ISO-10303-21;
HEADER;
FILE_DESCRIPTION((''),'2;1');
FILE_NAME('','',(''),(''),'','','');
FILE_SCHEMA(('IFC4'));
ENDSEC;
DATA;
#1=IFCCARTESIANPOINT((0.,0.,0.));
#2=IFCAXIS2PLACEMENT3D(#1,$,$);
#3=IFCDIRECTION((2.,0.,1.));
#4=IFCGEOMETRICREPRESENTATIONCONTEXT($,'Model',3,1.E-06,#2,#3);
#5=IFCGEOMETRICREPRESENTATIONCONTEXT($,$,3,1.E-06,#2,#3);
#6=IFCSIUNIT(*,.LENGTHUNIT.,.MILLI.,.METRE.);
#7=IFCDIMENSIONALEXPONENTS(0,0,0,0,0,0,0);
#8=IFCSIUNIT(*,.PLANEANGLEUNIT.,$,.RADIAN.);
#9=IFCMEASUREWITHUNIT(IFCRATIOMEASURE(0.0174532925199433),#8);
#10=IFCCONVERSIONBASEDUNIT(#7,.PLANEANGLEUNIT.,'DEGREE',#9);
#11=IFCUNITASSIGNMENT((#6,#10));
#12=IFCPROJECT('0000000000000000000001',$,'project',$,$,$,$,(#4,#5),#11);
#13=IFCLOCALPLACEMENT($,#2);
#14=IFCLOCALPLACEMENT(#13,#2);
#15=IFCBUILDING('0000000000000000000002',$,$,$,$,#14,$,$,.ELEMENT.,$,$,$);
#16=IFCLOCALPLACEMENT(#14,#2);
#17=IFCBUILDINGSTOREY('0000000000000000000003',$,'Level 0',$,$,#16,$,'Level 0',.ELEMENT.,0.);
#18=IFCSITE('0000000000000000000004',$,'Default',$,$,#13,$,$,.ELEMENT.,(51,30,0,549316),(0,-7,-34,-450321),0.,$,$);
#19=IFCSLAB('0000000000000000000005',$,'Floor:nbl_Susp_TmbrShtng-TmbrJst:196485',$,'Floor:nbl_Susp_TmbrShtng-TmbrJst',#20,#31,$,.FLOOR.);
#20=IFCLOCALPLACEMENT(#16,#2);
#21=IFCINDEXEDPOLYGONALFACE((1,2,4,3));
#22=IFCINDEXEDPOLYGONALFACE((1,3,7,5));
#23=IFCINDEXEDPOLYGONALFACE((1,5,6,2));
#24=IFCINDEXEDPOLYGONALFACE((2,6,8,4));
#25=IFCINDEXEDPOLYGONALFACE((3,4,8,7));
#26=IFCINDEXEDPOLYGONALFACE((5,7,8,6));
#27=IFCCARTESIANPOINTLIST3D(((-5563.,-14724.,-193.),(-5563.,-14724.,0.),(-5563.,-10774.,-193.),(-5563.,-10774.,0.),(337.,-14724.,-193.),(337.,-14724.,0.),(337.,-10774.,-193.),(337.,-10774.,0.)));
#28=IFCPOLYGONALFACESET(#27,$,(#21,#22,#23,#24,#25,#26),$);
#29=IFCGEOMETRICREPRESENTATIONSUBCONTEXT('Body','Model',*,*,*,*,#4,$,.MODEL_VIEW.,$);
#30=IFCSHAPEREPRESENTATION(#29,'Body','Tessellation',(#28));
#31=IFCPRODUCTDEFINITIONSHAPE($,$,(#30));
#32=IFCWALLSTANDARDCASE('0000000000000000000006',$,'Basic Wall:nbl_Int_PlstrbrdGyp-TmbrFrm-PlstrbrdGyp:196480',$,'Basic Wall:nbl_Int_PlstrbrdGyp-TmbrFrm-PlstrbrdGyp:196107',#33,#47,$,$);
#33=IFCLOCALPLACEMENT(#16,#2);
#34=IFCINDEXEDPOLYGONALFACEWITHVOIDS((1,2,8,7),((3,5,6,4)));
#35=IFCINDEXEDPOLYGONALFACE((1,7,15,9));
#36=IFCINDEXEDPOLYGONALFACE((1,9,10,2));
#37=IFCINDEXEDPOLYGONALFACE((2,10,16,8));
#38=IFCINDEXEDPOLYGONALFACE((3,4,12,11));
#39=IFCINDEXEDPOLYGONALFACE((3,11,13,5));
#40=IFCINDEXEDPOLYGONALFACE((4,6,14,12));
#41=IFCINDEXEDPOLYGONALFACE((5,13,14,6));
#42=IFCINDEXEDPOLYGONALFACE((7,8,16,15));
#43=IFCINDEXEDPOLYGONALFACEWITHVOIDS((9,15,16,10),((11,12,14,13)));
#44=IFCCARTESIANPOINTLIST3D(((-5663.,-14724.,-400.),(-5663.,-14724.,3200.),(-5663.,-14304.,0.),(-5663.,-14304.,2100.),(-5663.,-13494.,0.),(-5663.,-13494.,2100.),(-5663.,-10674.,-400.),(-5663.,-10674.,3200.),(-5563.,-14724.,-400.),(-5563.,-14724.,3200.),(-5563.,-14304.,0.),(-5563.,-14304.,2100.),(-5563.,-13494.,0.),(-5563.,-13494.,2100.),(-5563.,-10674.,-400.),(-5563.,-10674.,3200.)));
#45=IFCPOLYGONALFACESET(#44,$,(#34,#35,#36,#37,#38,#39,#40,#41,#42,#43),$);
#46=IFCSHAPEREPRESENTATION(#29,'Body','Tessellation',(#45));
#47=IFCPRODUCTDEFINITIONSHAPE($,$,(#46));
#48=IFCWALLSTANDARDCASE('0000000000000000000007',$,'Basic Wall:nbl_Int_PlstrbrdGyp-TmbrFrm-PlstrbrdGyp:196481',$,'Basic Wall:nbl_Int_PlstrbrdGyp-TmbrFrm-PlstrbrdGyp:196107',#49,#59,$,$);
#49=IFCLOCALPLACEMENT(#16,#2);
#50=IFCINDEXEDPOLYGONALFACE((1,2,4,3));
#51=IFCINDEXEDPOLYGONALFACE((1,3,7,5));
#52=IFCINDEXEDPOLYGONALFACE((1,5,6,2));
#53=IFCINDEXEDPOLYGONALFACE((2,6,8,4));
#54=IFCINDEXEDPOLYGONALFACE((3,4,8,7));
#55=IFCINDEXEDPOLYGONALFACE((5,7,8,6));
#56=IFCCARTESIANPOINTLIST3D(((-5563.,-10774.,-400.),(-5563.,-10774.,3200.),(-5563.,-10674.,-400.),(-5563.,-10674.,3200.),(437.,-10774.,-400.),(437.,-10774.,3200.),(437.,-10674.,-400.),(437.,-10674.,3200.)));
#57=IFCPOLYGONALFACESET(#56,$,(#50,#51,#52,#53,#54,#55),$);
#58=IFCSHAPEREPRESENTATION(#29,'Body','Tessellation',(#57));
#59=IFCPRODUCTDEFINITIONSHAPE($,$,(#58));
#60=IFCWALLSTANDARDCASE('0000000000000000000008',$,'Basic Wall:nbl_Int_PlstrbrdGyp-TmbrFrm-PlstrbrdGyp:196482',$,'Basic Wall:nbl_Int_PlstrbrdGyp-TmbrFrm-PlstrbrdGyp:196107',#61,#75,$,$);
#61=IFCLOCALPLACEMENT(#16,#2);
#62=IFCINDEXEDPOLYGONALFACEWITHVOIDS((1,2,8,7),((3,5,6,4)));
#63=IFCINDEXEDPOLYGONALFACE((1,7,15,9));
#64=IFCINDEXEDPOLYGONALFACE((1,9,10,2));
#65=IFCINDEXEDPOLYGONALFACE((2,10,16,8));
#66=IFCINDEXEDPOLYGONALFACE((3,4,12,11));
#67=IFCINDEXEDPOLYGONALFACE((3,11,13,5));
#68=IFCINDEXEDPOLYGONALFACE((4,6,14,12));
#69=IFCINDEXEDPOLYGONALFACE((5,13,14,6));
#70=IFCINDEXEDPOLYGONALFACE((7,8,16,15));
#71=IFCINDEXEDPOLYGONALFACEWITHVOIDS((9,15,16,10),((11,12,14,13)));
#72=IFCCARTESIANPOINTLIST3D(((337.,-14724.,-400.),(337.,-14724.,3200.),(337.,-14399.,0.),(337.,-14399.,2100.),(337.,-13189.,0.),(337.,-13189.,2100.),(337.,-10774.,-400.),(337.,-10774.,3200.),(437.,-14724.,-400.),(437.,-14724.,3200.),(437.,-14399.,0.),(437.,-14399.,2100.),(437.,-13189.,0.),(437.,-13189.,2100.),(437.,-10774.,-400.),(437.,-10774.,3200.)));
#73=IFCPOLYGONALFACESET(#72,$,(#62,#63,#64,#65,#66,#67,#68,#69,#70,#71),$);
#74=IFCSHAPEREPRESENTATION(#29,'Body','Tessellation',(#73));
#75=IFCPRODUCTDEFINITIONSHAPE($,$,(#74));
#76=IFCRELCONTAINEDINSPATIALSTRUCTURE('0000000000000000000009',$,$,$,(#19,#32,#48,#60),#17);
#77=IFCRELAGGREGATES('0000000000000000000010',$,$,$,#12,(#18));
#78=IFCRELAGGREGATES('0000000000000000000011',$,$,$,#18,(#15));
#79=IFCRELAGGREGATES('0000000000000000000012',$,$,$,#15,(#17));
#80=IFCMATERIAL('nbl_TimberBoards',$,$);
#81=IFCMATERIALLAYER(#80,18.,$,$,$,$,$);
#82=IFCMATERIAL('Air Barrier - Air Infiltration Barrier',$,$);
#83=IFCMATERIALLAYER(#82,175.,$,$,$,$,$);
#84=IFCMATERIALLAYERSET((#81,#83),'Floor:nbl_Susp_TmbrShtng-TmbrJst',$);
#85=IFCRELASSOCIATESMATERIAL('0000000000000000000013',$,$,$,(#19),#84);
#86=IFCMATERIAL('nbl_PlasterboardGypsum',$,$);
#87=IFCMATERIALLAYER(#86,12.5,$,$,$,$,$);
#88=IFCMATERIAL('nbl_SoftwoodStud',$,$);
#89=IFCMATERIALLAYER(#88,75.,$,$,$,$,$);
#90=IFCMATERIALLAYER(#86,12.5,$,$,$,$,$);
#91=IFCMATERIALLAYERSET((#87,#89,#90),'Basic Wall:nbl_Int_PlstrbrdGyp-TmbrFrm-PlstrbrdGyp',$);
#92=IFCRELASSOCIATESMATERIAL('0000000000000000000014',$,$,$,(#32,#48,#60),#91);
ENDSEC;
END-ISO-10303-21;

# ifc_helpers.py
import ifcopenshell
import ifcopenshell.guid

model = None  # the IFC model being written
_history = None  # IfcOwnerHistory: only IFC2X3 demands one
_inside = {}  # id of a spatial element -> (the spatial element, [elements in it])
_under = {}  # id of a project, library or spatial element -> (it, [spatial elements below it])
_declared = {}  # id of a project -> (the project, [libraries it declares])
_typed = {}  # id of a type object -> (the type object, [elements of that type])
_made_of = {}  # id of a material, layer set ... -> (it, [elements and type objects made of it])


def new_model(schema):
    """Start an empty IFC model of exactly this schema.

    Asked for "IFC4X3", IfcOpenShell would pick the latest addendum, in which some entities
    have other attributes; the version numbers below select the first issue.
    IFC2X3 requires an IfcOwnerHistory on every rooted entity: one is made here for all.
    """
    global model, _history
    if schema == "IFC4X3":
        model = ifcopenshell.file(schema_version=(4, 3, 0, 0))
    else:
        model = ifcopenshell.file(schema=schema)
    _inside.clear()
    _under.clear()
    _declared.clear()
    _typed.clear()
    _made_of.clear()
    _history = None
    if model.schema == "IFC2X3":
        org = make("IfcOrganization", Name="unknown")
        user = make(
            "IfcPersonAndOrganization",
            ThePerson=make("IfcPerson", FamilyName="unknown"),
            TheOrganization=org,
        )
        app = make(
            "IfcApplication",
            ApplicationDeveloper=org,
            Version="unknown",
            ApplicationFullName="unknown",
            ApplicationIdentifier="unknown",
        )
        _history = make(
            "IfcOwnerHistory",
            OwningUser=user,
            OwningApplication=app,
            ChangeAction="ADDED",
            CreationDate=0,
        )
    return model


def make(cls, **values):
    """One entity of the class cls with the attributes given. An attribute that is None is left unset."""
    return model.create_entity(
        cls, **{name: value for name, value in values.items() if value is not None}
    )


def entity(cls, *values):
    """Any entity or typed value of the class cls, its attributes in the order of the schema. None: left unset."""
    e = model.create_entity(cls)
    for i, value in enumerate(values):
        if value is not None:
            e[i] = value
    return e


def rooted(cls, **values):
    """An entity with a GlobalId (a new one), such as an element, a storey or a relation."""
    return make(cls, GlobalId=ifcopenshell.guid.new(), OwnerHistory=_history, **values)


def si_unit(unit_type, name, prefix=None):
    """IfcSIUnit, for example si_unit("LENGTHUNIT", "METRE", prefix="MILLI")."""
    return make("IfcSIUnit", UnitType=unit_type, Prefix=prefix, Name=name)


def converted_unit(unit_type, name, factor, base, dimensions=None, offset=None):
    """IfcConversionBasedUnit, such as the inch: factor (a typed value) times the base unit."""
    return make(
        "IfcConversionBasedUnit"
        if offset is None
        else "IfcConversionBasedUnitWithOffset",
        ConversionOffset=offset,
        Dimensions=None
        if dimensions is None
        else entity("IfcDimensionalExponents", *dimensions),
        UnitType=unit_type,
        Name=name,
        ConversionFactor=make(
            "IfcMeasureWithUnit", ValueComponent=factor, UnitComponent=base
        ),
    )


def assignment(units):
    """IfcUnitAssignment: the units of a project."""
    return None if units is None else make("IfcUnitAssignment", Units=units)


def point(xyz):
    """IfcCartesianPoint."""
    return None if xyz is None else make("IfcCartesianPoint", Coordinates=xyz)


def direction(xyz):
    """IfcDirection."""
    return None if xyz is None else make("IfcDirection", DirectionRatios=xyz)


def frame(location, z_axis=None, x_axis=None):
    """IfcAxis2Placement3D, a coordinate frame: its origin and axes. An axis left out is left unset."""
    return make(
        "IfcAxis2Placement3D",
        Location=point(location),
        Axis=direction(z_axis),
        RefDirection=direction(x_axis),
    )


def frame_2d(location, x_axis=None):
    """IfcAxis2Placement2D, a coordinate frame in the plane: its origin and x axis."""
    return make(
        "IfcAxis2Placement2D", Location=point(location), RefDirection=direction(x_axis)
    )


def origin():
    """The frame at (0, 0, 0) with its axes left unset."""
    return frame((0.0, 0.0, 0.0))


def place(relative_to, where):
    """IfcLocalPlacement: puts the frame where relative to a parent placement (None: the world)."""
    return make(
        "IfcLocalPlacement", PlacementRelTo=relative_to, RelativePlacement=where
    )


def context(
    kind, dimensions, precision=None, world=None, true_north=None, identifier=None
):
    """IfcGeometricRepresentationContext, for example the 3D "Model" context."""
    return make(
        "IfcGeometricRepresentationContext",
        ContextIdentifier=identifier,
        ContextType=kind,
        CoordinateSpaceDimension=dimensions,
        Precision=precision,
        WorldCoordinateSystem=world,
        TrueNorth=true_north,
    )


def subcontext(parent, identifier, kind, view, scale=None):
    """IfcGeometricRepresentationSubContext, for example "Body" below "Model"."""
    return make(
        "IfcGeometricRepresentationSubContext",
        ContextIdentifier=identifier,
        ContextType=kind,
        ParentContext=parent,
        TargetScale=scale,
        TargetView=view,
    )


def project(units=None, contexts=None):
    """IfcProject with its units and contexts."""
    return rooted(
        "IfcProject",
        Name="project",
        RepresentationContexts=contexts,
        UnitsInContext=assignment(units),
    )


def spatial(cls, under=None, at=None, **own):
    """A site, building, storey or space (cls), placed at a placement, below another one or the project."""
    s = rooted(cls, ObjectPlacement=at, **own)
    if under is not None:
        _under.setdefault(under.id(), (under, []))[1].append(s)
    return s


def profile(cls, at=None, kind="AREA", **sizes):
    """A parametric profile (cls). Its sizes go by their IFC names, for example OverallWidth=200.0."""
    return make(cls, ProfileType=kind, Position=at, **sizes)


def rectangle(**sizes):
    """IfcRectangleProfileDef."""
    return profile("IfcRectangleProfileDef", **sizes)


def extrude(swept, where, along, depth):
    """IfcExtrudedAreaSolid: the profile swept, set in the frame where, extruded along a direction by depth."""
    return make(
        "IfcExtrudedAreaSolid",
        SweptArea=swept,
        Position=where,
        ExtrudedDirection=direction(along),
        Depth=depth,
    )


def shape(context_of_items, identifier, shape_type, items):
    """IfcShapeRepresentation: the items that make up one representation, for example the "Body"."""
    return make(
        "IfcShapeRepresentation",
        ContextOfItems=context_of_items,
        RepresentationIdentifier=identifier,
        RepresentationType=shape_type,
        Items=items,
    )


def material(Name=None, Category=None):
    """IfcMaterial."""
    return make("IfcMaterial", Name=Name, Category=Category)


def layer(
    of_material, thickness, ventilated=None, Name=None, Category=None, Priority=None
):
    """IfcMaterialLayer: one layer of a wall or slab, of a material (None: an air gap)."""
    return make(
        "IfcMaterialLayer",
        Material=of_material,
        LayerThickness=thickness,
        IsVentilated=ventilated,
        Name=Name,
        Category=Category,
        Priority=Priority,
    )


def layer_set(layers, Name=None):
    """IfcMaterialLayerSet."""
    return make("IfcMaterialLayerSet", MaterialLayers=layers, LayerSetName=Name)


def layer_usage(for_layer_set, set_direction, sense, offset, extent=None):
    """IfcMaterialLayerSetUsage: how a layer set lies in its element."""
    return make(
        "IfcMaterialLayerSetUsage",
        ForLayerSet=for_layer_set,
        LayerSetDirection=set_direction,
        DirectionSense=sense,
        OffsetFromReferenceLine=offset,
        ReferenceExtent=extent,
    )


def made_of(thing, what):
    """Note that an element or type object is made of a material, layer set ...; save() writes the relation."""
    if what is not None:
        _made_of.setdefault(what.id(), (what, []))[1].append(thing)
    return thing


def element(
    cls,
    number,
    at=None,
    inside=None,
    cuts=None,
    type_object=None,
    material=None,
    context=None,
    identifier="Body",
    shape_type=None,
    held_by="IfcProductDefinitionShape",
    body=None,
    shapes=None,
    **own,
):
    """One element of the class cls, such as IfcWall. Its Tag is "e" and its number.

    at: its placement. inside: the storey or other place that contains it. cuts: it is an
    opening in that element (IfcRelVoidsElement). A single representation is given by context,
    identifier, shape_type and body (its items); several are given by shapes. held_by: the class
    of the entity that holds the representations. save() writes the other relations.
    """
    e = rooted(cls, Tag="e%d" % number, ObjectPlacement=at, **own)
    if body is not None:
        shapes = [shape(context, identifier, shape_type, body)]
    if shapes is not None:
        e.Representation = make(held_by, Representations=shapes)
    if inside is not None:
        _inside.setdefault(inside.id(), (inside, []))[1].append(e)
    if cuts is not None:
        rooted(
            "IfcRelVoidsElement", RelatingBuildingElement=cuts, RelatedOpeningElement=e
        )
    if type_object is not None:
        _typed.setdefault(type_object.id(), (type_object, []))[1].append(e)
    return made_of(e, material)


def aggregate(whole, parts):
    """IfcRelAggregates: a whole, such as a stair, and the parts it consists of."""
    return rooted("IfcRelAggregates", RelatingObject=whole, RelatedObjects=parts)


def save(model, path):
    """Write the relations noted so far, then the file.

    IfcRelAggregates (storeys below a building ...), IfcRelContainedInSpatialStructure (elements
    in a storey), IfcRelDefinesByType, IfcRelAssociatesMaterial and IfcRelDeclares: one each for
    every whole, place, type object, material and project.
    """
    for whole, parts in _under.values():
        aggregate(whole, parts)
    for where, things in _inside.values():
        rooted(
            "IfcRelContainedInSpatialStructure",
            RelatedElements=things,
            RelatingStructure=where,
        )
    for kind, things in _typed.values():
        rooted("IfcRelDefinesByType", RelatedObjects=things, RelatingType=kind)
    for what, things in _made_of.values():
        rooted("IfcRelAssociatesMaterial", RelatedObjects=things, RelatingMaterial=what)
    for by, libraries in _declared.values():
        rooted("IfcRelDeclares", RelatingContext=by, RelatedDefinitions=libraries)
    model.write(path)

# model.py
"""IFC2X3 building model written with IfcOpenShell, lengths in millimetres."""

from ifc_helpers import new_model, entity, si_unit, converted_unit, direction, frame, frame_2d, origin, place, context, subcontext, project, spatial, rectangle, extrude, material, layer, layer_set, layer_usage, element, save


model = new_model("IFC2X3")

# Units and contexts
model_context = context("Model", 3, precision=1e-06, world=origin(), true_north=direction((2.0, 0.0, 1.0)))
context_of_model = context(None, 3, precision=1e-06, world=origin(), true_north=direction((2.0, 0.0, 1.0)))
body_context = subcontext(model_context, "Body", "Model", "MODEL_VIEW")
ifc_project = project(units=[si_unit("LENGTHUNIT", "METRE", prefix="MILLI"), converted_unit("PLANEANGLEUNIT", "DEGREE", entity("IfcRatioMeasure", 0.0174532925199433), si_unit("PLANEANGLEUNIT", "RADIAN"), dimensions=[0, 0, 0, 0, 0, 0, 0])], contexts=[model_context, context_of_model])

# Site, building, storey
site_placement = place(None, origin())
site = spatial("IfcSite", under=ifc_project, at=site_placement, Name="Default", CompositionType="ELEMENT", RefLatitude=(51, 30, 0, 549316), RefLongitude=(0, -7, -34, -450321), RefElevation=0.0)
building_placement = place(site_placement, origin())
building = spatial("IfcBuilding", under=site, at=building_placement, CompositionType="ELEMENT")
storey_placement = place(building_placement, origin())
storey = spatial("IfcBuildingStorey", under=building, at=storey_placement, Name="Level 0", LongName="Level 0", CompositionType="ELEMENT", Elevation=0.0)

# Slab
ifc_material_1 = material(Name="nbl_TimberBoards")
ifc_layer_1 = layer(ifc_material_1, 18.0)
ifc_material_2 = material(Name="Air Barrier - Air Infiltration Barrier")
ifc_layer_2 = layer(ifc_material_2, 175.0)
ifc_layer_set_1 = layer_set([ifc_layer_1, ifc_layer_2], Name="Floor:nbl_Susp_TmbrShtng-TmbrJst")
ifc_layer_usage_1 = layer_usage(ifc_layer_set_1, "AXIS3", "POSITIVE", 0.0)
slab_placement = place(storey_placement, frame((-5563.0, -14724.0, -193.0)))
element("IfcSlab", 1, at=slab_placement, inside=storey, material=ifc_layer_usage_1, Name="Floor:nbl_Susp_TmbrShtng-TmbrJst:196485", ObjectType="Floor:nbl_Susp_TmbrShtng-TmbrJst", PredefinedType="FLOOR", context=body_context, shape_type="SweptSolid", body=[
    extrude(rectangle(XDim=3950.0, YDim=5900.0, at=frame_2d((0.0, 0.0), x_axis=(0.0, -1.0))), frame((2950.0, 1975.0, 193.0), z_axis=(0.0, 0.0, -1.0), x_axis=(-1.0, 0.0, 0.0)), (0.0, 0.0, 1.0), 193.0),
])

# Wall, opening
ifc_material_3 = material(Name="nbl_PlasterboardGypsum")
ifc_layer_3 = layer(ifc_material_3, 12.5)
ifc_material_4 = material(Name="nbl_SoftwoodStud")
ifc_layer_4 = layer(ifc_material_4, 75.0)
ifc_layer_5 = layer(ifc_material_3, 12.5)
ifc_layer_set_2 = layer_set([ifc_layer_3, ifc_layer_4, ifc_layer_5], Name="Basic Wall:nbl_Int_PlstrbrdGyp-TmbrFrm-PlstrbrdGyp")
ifc_layer_usage_2 = layer_usage(ifc_layer_set_2, "AXIS2", "NEGATIVE", 50.0)
wall_1_placement = place(storey_placement, frame((-5613.0, -14724.0, -400.0), z_axis=(0.0, 0.0, 1.0), x_axis=(0.0, 1.0, 0.0)))
wall_1 = element("IfcWallStandardCase", 2, at=wall_1_placement, inside=storey, material=ifc_layer_usage_2, Name="Basic Wall:nbl_Int_PlstrbrdGyp-TmbrFrm-PlstrbrdGyp:196480", ObjectType="Basic Wall:nbl_Int_PlstrbrdGyp-TmbrFrm-PlstrbrdGyp:196107", context=body_context, shape_type="SweptSolid", body=[
    extrude(rectangle(XDim=4050.0, YDim=100.0, at=frame_2d((2025.0, 0.0), x_axis=(-1.0, 0.0))), origin(), (0.0, 0.0, 1.0), 3600.0),
])
opening_1_placement = place(wall_1_placement, frame((420.0, -50.0, 400.0)))
element("IfcOpeningElement", 3, at=opening_1_placement, cuts=wall_1, ObjectType="Opening", context=body_context, shape_type="SweptSolid", body=[
    extrude(rectangle(XDim=2100.0, YDim=810.0, at=frame_2d((1050.0, 405.0), x_axis=(-1.0, 0.0))), frame((0.0, 0.0, 0.0), z_axis=(0.0, 1.0, 0.0), x_axis=(0.0, 0.0, 1.0)), (0.0, 0.0, 1.0), 100.0),
])

# Wall
ifc_layer_usage_3 = layer_usage(ifc_layer_set_2, "AXIS2", "NEGATIVE", 50.0)
wall_2_placement = place(storey_placement, frame((-5563.0, -10724.0, -400.0)))
element("IfcWallStandardCase", 4, at=wall_2_placement, inside=storey, material=ifc_layer_usage_3, Name="Basic Wall:nbl_Int_PlstrbrdGyp-TmbrFrm-PlstrbrdGyp:196481", ObjectType="Basic Wall:nbl_Int_PlstrbrdGyp-TmbrFrm-PlstrbrdGyp:196107", context=body_context, shape_type="SweptSolid", body=[
    extrude(rectangle(XDim=6000.0, YDim=100.0, at=frame_2d((3000.0, 0.0), x_axis=(-1.0, 0.0))), origin(), (0.0, 0.0, 1.0), 3600.0),
])

# Wall, opening
ifc_layer_usage_4 = layer_usage(ifc_layer_set_2, "AXIS2", "NEGATIVE", 50.0)
wall_3_placement = place(storey_placement, frame((387.0, -10774.0, -400.0), z_axis=(0.0, 0.0, 1.0), x_axis=(0.0, -1.0, 0.0)))
wall_3 = element("IfcWallStandardCase", 5, at=wall_3_placement, inside=storey, material=ifc_layer_usage_4, Name="Basic Wall:nbl_Int_PlstrbrdGyp-TmbrFrm-PlstrbrdGyp:196482", ObjectType="Basic Wall:nbl_Int_PlstrbrdGyp-TmbrFrm-PlstrbrdGyp:196107", context=body_context, shape_type="SweptSolid", body=[
    extrude(rectangle(XDim=3950.0, YDim=100.0, at=frame_2d((1975.0, 0.0), x_axis=(-1.0, 0.0))), origin(), (0.0, 0.0, 1.0), 3600.0),
])
opening_2_placement = place(wall_3_placement, frame((3625.0, 50.0, 400.0)))
element("IfcOpeningElement", 6, at=opening_2_placement, cuts=wall_3, ObjectType="Opening", context=body_context, shape_type="SweptSolid", body=[
    extrude(rectangle(XDim=2100.0, YDim=1210.0, at=frame_2d((1050.0, 605.0), x_axis=(-1.0, 0.0))), frame((0.0, 0.0, 0.0), z_axis=(0.0, -1.0, 0.0), x_axis=(0.0, 0.0, 1.0)), (0.0, 0.0, 1.0), 100.0),
])

save(model, "model.ifc")
